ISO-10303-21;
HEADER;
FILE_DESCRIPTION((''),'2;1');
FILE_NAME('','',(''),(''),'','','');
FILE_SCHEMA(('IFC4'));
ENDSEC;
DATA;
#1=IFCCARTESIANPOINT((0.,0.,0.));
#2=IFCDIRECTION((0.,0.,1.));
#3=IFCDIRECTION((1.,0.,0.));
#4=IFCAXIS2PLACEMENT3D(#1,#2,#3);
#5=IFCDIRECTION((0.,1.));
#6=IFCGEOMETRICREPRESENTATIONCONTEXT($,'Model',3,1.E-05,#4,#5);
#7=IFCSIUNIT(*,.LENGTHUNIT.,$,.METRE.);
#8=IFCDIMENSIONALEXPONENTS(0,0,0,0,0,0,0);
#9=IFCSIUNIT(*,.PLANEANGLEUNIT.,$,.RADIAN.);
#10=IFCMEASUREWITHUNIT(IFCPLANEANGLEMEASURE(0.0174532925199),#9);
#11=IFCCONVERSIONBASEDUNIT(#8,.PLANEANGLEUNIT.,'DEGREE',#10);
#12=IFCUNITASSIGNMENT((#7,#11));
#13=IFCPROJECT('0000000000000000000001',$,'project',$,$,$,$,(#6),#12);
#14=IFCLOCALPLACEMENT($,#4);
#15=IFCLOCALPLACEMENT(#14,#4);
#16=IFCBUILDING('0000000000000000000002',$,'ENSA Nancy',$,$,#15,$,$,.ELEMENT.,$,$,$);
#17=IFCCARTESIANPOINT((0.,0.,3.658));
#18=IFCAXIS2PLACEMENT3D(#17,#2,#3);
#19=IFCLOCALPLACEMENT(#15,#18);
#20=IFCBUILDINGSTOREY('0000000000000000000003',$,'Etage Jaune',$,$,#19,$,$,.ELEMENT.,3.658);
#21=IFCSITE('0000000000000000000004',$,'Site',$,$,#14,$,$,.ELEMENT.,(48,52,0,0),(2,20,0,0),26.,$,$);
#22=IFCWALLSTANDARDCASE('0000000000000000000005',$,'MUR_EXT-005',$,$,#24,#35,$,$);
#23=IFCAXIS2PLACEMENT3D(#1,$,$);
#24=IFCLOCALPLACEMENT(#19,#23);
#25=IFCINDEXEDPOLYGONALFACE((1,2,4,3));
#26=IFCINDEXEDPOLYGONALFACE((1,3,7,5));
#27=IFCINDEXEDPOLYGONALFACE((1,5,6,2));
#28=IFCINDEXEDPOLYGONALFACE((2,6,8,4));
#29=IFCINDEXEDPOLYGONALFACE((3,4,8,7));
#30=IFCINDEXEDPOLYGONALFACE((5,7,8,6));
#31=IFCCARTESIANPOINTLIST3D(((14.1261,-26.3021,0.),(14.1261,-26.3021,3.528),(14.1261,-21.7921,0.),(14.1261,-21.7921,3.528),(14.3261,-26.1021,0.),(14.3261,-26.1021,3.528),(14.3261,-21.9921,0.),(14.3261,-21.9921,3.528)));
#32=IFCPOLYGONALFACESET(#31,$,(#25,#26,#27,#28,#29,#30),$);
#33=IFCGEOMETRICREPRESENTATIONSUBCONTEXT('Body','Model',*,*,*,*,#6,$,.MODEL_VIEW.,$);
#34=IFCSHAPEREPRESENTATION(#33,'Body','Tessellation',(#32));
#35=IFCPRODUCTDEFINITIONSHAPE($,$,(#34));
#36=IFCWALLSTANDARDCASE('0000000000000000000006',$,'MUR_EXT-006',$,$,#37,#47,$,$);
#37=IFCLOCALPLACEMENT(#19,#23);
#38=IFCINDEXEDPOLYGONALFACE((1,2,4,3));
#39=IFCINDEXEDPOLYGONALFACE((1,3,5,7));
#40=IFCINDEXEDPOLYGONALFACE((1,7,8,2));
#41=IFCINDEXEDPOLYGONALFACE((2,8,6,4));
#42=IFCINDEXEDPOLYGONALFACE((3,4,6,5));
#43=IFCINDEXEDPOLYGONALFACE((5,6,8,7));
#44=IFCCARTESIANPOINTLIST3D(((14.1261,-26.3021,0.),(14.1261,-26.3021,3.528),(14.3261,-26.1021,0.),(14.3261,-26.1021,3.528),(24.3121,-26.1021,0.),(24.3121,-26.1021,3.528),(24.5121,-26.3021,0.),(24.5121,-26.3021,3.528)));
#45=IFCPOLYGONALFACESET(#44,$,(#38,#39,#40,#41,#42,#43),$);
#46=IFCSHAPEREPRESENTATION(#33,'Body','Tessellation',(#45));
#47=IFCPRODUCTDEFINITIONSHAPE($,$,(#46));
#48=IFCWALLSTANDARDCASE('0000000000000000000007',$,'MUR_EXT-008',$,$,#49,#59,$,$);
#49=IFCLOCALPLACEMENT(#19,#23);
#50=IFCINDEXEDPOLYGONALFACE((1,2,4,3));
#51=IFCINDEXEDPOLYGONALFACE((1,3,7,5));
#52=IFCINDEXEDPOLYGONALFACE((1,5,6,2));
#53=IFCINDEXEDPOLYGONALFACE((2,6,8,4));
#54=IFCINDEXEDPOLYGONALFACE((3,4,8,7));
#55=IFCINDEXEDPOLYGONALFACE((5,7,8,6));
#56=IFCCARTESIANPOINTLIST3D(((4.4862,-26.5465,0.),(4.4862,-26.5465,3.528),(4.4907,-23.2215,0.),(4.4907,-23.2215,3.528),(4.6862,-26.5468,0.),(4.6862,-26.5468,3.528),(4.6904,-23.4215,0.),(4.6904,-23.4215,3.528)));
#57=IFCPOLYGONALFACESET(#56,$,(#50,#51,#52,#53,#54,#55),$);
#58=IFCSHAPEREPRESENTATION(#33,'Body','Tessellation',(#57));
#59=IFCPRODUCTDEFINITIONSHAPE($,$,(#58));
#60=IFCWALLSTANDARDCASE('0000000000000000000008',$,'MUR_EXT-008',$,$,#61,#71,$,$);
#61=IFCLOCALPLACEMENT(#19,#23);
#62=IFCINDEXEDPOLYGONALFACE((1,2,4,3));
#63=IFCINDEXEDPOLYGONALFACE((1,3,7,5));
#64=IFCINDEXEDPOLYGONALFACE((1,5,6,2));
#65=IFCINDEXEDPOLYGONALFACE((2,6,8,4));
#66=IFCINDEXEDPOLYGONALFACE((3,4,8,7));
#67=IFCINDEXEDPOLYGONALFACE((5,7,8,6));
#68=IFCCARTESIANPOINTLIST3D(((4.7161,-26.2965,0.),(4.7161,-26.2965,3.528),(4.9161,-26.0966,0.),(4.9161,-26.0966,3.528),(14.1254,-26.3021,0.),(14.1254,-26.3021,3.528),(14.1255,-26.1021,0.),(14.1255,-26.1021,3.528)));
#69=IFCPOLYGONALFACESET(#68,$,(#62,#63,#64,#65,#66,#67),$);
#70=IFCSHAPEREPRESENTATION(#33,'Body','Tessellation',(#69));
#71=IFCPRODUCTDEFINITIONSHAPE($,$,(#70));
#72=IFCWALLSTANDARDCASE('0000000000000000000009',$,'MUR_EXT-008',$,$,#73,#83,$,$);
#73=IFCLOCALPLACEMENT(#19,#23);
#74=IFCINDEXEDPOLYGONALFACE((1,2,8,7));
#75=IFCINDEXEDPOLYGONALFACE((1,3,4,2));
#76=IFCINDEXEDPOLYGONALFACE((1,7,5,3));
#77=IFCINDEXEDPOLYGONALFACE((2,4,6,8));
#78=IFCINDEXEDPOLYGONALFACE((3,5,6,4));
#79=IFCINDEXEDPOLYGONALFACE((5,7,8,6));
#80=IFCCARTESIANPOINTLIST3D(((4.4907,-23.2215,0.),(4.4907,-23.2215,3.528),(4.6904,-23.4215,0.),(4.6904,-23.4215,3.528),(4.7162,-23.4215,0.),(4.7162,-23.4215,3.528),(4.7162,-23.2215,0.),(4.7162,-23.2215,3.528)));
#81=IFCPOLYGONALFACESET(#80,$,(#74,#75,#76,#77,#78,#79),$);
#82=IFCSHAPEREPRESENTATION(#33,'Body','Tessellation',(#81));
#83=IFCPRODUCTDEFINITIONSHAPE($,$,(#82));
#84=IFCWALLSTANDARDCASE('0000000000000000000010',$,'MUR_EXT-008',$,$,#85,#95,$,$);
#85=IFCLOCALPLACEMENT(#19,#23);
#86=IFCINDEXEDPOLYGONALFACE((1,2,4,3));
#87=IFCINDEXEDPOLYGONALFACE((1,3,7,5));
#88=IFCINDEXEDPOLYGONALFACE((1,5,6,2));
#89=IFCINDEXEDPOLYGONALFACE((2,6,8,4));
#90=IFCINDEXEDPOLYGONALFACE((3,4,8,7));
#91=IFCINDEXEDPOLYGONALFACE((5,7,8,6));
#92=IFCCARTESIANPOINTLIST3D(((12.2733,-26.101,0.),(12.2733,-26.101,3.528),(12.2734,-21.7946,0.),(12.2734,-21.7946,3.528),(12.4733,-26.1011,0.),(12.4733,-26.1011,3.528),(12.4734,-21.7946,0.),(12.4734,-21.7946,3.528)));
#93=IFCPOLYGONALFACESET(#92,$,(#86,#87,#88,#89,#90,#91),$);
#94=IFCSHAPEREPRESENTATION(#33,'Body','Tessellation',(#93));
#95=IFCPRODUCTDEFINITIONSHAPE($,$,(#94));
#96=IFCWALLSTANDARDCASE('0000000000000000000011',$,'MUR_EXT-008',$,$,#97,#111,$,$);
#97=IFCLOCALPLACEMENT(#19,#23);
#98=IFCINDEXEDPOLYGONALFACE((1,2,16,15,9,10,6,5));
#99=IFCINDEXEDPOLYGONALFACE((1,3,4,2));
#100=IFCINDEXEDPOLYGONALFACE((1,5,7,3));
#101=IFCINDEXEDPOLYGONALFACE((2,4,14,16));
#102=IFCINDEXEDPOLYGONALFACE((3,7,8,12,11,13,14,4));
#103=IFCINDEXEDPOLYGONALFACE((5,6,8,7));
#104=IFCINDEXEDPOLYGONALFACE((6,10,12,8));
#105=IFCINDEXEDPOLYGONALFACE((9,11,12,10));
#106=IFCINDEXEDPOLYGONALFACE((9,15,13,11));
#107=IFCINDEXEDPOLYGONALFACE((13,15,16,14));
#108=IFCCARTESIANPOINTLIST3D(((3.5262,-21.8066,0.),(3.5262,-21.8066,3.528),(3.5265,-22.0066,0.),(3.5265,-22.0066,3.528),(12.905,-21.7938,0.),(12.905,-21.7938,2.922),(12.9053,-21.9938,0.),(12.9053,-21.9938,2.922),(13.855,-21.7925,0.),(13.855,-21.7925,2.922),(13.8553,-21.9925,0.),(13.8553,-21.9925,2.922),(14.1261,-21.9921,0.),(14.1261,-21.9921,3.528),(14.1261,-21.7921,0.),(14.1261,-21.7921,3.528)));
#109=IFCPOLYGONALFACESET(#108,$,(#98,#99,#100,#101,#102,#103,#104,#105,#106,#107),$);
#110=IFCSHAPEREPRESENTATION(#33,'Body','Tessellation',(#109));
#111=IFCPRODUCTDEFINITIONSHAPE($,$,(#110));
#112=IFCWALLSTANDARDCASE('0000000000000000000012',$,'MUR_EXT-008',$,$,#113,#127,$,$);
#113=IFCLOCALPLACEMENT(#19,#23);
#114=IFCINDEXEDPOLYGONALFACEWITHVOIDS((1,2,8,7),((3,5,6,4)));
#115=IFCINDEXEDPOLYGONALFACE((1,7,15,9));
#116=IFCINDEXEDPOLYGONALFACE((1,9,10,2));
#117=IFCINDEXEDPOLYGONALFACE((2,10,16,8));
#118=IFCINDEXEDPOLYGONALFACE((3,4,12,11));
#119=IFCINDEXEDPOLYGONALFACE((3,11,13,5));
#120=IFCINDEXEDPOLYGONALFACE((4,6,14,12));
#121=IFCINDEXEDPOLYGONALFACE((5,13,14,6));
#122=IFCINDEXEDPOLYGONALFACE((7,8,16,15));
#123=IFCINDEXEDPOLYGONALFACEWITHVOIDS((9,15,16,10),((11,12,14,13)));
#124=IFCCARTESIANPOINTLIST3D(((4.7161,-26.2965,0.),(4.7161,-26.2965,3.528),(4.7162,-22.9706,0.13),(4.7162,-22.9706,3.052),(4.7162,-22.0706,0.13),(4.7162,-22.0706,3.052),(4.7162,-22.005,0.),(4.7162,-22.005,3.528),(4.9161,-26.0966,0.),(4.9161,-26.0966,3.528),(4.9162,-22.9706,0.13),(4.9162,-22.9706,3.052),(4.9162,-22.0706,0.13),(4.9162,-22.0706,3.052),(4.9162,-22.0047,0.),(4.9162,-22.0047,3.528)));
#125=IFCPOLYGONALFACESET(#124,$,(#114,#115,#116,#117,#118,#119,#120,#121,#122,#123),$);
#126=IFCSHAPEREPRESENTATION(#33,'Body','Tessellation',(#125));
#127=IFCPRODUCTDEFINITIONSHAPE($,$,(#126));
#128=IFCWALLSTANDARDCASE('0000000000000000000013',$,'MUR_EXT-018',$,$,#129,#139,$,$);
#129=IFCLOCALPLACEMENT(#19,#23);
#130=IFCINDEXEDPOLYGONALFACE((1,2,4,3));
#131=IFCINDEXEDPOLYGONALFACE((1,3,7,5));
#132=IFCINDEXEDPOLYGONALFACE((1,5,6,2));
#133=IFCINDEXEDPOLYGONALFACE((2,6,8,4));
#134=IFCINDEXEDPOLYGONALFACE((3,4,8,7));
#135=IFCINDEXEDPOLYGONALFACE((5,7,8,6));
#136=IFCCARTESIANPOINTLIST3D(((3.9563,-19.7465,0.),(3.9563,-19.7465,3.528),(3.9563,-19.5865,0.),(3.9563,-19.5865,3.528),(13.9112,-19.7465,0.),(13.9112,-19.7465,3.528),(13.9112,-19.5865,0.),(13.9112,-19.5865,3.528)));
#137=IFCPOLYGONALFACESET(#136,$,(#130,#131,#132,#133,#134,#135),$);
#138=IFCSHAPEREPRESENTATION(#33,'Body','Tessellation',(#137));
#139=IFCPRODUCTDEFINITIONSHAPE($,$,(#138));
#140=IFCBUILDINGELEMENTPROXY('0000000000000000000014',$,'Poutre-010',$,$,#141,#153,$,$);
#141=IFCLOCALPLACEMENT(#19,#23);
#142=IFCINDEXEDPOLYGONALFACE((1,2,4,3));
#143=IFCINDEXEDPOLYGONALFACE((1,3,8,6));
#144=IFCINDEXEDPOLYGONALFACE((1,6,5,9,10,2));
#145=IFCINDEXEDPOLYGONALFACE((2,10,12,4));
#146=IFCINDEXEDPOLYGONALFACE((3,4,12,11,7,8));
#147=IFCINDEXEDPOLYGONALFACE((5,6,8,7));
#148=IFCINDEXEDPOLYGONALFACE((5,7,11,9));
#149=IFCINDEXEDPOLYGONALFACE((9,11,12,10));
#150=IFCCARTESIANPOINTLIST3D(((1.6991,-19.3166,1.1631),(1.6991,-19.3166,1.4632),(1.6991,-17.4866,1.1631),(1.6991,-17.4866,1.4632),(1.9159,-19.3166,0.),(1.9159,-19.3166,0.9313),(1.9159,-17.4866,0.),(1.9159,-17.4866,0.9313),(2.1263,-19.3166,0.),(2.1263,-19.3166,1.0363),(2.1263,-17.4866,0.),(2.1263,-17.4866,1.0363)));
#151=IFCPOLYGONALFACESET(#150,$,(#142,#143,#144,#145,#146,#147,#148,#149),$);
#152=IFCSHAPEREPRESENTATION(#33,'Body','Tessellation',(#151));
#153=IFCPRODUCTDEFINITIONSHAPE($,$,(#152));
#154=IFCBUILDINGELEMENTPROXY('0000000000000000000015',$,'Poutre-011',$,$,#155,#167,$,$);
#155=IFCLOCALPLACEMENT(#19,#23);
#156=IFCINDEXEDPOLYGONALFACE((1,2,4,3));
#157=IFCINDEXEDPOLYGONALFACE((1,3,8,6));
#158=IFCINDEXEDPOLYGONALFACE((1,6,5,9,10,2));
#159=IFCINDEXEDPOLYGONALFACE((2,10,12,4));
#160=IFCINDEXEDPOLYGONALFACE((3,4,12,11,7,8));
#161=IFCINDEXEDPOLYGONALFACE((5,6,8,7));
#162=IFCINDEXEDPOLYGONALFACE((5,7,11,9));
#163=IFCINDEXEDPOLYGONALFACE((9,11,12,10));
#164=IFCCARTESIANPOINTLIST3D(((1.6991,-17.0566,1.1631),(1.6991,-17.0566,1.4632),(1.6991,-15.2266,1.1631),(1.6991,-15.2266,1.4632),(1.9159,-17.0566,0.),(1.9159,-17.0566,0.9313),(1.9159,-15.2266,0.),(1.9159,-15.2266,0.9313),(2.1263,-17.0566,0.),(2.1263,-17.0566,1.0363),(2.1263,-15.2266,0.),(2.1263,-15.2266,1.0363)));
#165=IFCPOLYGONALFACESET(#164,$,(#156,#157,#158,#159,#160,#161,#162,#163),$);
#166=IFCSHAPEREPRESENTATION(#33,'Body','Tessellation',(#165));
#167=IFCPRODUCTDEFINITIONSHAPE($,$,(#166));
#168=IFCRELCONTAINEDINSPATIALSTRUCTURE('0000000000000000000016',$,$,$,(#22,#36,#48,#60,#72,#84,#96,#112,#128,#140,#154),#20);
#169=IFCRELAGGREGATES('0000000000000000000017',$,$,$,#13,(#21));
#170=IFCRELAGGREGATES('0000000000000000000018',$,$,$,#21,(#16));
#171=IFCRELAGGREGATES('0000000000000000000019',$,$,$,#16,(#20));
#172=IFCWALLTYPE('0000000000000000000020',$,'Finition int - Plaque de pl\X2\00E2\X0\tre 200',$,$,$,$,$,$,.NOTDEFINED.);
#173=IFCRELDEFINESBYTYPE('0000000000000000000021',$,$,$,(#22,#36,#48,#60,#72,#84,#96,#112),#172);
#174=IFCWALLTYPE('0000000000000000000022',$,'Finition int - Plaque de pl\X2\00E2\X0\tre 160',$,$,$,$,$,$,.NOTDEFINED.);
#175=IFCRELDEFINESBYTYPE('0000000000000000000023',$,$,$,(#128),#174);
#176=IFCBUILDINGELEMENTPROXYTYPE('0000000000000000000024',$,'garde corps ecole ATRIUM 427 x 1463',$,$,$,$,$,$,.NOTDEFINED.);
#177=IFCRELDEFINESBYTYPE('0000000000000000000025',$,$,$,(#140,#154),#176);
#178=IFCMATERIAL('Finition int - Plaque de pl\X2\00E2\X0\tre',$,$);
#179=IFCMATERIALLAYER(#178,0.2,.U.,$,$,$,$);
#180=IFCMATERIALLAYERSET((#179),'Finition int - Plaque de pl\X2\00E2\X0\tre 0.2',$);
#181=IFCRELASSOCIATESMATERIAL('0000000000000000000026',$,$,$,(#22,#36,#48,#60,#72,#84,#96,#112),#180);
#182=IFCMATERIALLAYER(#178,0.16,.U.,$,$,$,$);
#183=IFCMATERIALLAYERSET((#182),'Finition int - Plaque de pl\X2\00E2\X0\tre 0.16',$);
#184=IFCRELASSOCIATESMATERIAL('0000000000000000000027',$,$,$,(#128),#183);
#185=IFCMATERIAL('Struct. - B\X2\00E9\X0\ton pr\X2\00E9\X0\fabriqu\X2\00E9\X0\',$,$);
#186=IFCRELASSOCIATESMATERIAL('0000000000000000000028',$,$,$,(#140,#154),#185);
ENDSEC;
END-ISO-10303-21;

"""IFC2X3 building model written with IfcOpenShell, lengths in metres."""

from ifc_helpers import new_model, entity, si_unit, converted_unit, direction, frame, origin_with_axes, origin_2d_with_axis, place, context, subcontext, project, spatial, polyline, rectangle, outline, extrude, material, layer, layer_set, layer_usage, type_object, element, save


model = new_model("IFC2X3")

# Units and contexts
model_context = context("Model", 3, precision=1e-05, world=origin_with_axes(), true_north=direction((0.0, 1.0)))
body_context = subcontext(model_context, "Body", "Model", "MODEL_VIEW")
ifc_project = project(units=[si_unit("LENGTHUNIT", "METRE"), converted_unit("PLANEANGLEUNIT", "DEGREE", entity("IfcPlaneAngleMeasure", 0.0174532925199), si_unit("PLANEANGLEUNIT", "RADIAN"), dimensions=[0, 0, 0, 0, 0, 0, 0])], contexts=[model_context])

# Site, building, storey
site_placement = place(None, origin_with_axes())
site = spatial("IfcSite", under=ifc_project, at=site_placement, Name="Site", CompositionType="ELEMENT", RefLatitude=(48, 52, 0, 0), RefLongitude=(2, 20, 0, 0), RefElevation=26.0)
building_placement = place(site_placement, origin_with_axes())
building = spatial("IfcBuilding", under=site, at=building_placement, Name="ENSA Nancy", CompositionType="ELEMENT")
storey_placement = place(building_placement, frame((0.0, 0.0, 3.658), z_axis=(0.0, 0.0, 1.0), x_axis=(1.0, 0.0, 0.0)))
storey = spatial("IfcBuildingStorey", under=building, at=storey_placement, Name="Etage Jaune", CompositionType="ELEMENT", Elevation=3.658)

# Walls
ifc_material_1 = material(Name="Finition int - Plaque de plâtre")
ifc_layer_1 = layer(ifc_material_1, 0.2, ventilated="UNKNOWN")
ifc_layer_set_1 = layer_set([ifc_layer_1], Name="Finition int - Plaque de plâtre 0.2")
ifc_layer_usage_1 = layer_usage(ifc_layer_set_1, "AXIS2", "POSITIVE", 0.0)
wall_type_1 = type_object("IfcWallType", Name="Finition int - Plaque de plâtre 200", PredefinedType="NOTDEFINED")
wall_1_placement = place(storey_placement, frame((14.1261, -21.7921, 0.0), z_axis=(0.0, 0.0, 1.0), x_axis=(0.0, -1.0, 0.0)))
element("IfcWallStandardCase", 1, at=wall_1_placement, inside=storey, type_object=wall_type_1, material=ifc_layer_usage_1, Name="MUR_EXT-005", context=body_context, shape_type="SweptSolid", body=[
    extrude(outline(polyline([(0.0, 0.0), (4.51, 0.0), (4.31, 0.2), (0.2, 0.2), (0.0, 0.0)])), origin_with_axes(), (0.0, 0.0, 1.0), 3.528),
])
ifc_layer_usage_2 = layer_usage(ifc_layer_set_1, "AXIS2", "POSITIVE", 0.0)
wall_2_placement = place(storey_placement, frame((14.1261, -26.3021, 0.0), z_axis=(0.0, 0.0, 1.0), x_axis=(1.0, 0.000003, 0.0)))
element("IfcWallStandardCase", 2, at=wall_2_placement, inside=storey, type_object=wall_type_1, material=ifc_layer_usage_2, Name="MUR_EXT-006", context=body_context, shape_type="SweptSolid", body=[
    extrude(outline(polyline([(0.0, 0.0), (10.386, 0.0), (10.186, 0.2), (0.2, 0.2), (0.0, 0.0)])), origin_with_axes(), (0.0, 0.0, 1.0), 3.528),
])
ifc_layer_usage_3 = layer_usage(ifc_layer_set_1, "AXIS2", "POSITIVE", 0.0)
wall_3_placement = place(storey_placement, frame((4.4907, -23.2215, 0.0), z_axis=(0.0, 0.0, 1.0), x_axis=(-0.001341, -0.999999, 0.0)))
element("IfcWallStandardCase", 3, at=wall_3_placement, inside=storey, type_object=wall_type_1, material=ifc_layer_usage_3, Name="MUR_EXT-008", context=body_context, shape_type="SweptSolid", body=[
    extrude(outline(polyline([(0.0, 0.0), (3.325, 0.0), (3.325, 0.2), (0.1997, 0.2), (0.0, 0.0)])), origin_with_axes(), (0.0, 0.0, 1.0), 3.528),
])
ifc_layer_usage_4 = layer_usage(ifc_layer_set_1, "AXIS2", "POSITIVE", 0.0)
wall_4_placement = place(storey_placement, frame((4.7161, -26.2965, 0.0), z_axis=(0.0, 0.0, 1.0), x_axis=(1.0, -0.000596, 0.0)))
element("IfcWallStandardCase", 4, at=wall_4_placement, inside=storey, type_object=wall_type_1, material=ifc_layer_usage_4, Name="MUR_EXT-008", context=body_context, shape_type="SweptSolid", body=[
    extrude(outline(polyline([(0.0, 0.0), (9.4092, 0.0), (9.4092, 0.2), (0.1999, 0.2), (0.0, 0.0)])), origin_with_axes(), (0.0, 0.0, 1.0), 3.528),
])
ifc_layer_usage_5 = layer_usage(ifc_layer_set_1, "AXIS2", "POSITIVE", 0.0)
wall_5_placement = place(storey_placement, frame((4.7162, -23.2215, 0.0), z_axis=(0.0, 0.0, 1.0), x_axis=(-1.0, 0.0, 0.0)))
element("IfcWallStandardCase", 5, at=wall_5_placement, inside=storey, type_object=wall_type_1, material=ifc_layer_usage_5, Name="MUR_EXT-008", context=body_context, shape_type="SweptSolid", body=[
    extrude(outline(polyline([(0.0, 0.0), (0.2255, 0.0), (0.0258, 0.2), (0.0, 0.2), (0.0, 0.0)])), origin_with_axes(), (0.0, 0.0, 1.0), 3.528),
])
ifc_layer_usage_6 = layer_usage(ifc_layer_set_1, "AXIS2", "POSITIVE", 0.0)
wall_6_placement = place(storey_placement, frame((12.2734, -21.7946, 0.0), z_axis=(0.0, 0.0, 1.0), x_axis=(-0.000007, -1.0, 0.0)))
element("IfcWallStandardCase", 6, at=wall_6_placement, inside=storey, type_object=wall_type_1, material=ifc_layer_usage_6, Name="MUR_EXT-008", context=body_context, shape_type="SweptSolid", body=[
    extrude(outline(polyline([(0.0, 0.0), (4.3065, 0.0), (4.3066, 0.2), (0.0, 0.2), (0.0, 0.0)])), origin_with_axes(), (0.0, 0.0, 1.0), 3.528),
])

# Wall, opening
ifc_layer_usage_7 = layer_usage(ifc_layer_set_1, "AXIS2", "NEGATIVE", 0.0)
wall_7_placement = place(storey_placement, frame((3.5262, -21.8066, 0.0), z_axis=(0.0, 0.0, 1.0), x_axis=(0.999999, 0.001365, 0.0)))
wall_7 = element("IfcWallStandardCase", 7, at=wall_7_placement, inside=storey, type_object=wall_type_1, material=ifc_layer_usage_7, Name="MUR_EXT-008", context=body_context, shape_type="SweptSolid", body=[
    extrude(outline(polyline([(0.0, -0.2), (10.5996, -0.2), (10.5999, 0.0), (0.0, 0.0), (0.0, -0.2)])), origin_with_axes(), (0.0, 0.0, 1.0), 3.528),
])
opening_1_placement = place(wall_7_placement, frame((9.8538, 0.0, 0.0), z_axis=(0.0, 0.0, 1.0), x_axis=(1.0, 0.0, 0.0)))
element("IfcOpeningElement", 8, at=opening_1_placement, cuts=wall_7, context=body_context, shape_type="SweptSolid", body=[
    extrude(rectangle(XDim=0.95, YDim=2.922, at=origin_2d_with_axis()), frame((0.0, -0.2, 1.461), z_axis=(0.0, 1.0, 0.0), x_axis=(1.0, 0.0, 0.0)), (0.0, 0.0, 1.0), 0.6),
])

# Wall, opening
ifc_layer_usage_8 = layer_usage(ifc_layer_set_1, "AXIS2", "POSITIVE", 0.0)
wall_8_placement = place(storey_placement, frame((4.7162, -21.805, 0.0), z_axis=(0.0, 0.0, 1.0), x_axis=(-0.000007, -1.0, 0.0)))
wall_8 = element("IfcWallStandardCase", 9, at=wall_8_placement, inside=storey, type_object=wall_type_1, material=ifc_layer_usage_8, Name="MUR_EXT-008", context=body_context, shape_type="SweptSolid", body=[
    extrude(outline(polyline([(0.2, 0.0), (4.4915, 0.0), (4.2917, 0.2), (0.1997, 0.2), (0.2, 0.0)])), origin_with_axes(), (0.0, 0.0, 1.0), 3.528),
])
opening_2_placement = place(wall_8_placement, frame((0.7156, 0.0, 0.13), z_axis=(0.0, 0.0, 1.0), x_axis=(1.0, 0.0, 0.0)))
element("IfcOpeningElement", 10, at=opening_2_placement, cuts=wall_8, context=body_context, shape_type="SweptSolid", body=[
    extrude(rectangle(XDim=0.9, YDim=2.922, at=origin_2d_with_axis()), frame((0.0, 0.2, 1.461), z_axis=(0.0, 1.0, 0.0), x_axis=(-1.0, 0.0, 0.0)), (0.0, 0.0, -1.0), 0.6),
])

# Wall
ifc_layer_2 = layer(ifc_material_1, 0.16, ventilated="UNKNOWN")
ifc_layer_set_2 = layer_set([ifc_layer_2], Name="Finition int - Plaque de plâtre 0.16")
ifc_layer_usage_9 = layer_usage(ifc_layer_set_2, "AXIS2", "POSITIVE", -0.16)
wall_type_2 = type_object("IfcWallType", Name="Finition int - Plaque de plâtre 160", PredefinedType="NOTDEFINED")
wall_9_placement = place(storey_placement, frame((3.9563, -19.5865, 0.0), z_axis=(0.0, 0.0, 1.0), x_axis=(1.0, 0.0, 0.0)))
element("IfcWallStandardCase", 11, at=wall_9_placement, inside=storey, type_object=wall_type_2, material=ifc_layer_usage_9, Name="MUR_EXT-018", context=body_context, shape_type="SweptSolid", body=[
    extrude(outline(polyline([(0.0, -0.16), (9.955, -0.16), (9.955, 0.0), (0.0, 0.0), (0.0, -0.16)])), origin_with_axes(), (0.0, 0.0, 1.0), 3.528),
])

# Building element proxies
ifc_material_2 = material(Name="Struct. - Béton préfabriqué")
building_element_proxy_type_1 = type_object("IfcBuildingElementProxyType", Name="garde corps ecole ATRIUM 427 x 1463", PredefinedType="NOTDEFINED")
proxy_1_placement = place(storey_placement, frame((2.1263, -19.3166, 0.0), z_axis=(0.0, 0.0, 1.0), x_axis=(1.0, 0.0, 0.0)))
element("IfcBuildingElementProxy", 12, at=proxy_1_placement, inside=storey, type_object=building_element_proxy_type_1, material=ifc_material_2, Name="Poutre-010", context=body_context, shape_type="SweptSolid", body=[
    extrude(outline(polyline([(0.0, 1.0363), (0.0, 0.0), (0.2105, 0.0), (0.2105, 0.9313), (0.4272, 1.1631), (0.4272, 1.4632), (0.0, 1.0363)])), frame((0.0, 1.83, 0.0), z_axis=(0.0, 1.0, 0.0), x_axis=(-1.0, 0.0, 0.0)), (0.0, 0.0, -1.0), 1.83),
])
proxy_2_placement = place(storey_placement, frame((2.1263, -17.0566, 0.0), z_axis=(0.0, 0.0, 1.0), x_axis=(1.0, 0.0, 0.0)))
element("IfcBuildingElementProxy", 13, at=proxy_2_placement, inside=storey, type_object=building_element_proxy_type_1, material=ifc_material_2, Name="Poutre-011", context=body_context, shape_type="SweptSolid", body=[
    extrude(outline(polyline([(0.0, 1.0363), (0.0, 0.0), (0.2105, 0.0), (0.2105, 0.9313), (0.4272, 1.1631), (0.4272, 1.4632), (0.0, 1.0363)])), frame((0.0, 1.83, 0.0), z_axis=(0.0, 1.0, 0.0), x_axis=(-1.0, 0.0, 0.0)), (0.0, 0.0, -1.0), 1.83),
])

save(model, "model.ifc")
